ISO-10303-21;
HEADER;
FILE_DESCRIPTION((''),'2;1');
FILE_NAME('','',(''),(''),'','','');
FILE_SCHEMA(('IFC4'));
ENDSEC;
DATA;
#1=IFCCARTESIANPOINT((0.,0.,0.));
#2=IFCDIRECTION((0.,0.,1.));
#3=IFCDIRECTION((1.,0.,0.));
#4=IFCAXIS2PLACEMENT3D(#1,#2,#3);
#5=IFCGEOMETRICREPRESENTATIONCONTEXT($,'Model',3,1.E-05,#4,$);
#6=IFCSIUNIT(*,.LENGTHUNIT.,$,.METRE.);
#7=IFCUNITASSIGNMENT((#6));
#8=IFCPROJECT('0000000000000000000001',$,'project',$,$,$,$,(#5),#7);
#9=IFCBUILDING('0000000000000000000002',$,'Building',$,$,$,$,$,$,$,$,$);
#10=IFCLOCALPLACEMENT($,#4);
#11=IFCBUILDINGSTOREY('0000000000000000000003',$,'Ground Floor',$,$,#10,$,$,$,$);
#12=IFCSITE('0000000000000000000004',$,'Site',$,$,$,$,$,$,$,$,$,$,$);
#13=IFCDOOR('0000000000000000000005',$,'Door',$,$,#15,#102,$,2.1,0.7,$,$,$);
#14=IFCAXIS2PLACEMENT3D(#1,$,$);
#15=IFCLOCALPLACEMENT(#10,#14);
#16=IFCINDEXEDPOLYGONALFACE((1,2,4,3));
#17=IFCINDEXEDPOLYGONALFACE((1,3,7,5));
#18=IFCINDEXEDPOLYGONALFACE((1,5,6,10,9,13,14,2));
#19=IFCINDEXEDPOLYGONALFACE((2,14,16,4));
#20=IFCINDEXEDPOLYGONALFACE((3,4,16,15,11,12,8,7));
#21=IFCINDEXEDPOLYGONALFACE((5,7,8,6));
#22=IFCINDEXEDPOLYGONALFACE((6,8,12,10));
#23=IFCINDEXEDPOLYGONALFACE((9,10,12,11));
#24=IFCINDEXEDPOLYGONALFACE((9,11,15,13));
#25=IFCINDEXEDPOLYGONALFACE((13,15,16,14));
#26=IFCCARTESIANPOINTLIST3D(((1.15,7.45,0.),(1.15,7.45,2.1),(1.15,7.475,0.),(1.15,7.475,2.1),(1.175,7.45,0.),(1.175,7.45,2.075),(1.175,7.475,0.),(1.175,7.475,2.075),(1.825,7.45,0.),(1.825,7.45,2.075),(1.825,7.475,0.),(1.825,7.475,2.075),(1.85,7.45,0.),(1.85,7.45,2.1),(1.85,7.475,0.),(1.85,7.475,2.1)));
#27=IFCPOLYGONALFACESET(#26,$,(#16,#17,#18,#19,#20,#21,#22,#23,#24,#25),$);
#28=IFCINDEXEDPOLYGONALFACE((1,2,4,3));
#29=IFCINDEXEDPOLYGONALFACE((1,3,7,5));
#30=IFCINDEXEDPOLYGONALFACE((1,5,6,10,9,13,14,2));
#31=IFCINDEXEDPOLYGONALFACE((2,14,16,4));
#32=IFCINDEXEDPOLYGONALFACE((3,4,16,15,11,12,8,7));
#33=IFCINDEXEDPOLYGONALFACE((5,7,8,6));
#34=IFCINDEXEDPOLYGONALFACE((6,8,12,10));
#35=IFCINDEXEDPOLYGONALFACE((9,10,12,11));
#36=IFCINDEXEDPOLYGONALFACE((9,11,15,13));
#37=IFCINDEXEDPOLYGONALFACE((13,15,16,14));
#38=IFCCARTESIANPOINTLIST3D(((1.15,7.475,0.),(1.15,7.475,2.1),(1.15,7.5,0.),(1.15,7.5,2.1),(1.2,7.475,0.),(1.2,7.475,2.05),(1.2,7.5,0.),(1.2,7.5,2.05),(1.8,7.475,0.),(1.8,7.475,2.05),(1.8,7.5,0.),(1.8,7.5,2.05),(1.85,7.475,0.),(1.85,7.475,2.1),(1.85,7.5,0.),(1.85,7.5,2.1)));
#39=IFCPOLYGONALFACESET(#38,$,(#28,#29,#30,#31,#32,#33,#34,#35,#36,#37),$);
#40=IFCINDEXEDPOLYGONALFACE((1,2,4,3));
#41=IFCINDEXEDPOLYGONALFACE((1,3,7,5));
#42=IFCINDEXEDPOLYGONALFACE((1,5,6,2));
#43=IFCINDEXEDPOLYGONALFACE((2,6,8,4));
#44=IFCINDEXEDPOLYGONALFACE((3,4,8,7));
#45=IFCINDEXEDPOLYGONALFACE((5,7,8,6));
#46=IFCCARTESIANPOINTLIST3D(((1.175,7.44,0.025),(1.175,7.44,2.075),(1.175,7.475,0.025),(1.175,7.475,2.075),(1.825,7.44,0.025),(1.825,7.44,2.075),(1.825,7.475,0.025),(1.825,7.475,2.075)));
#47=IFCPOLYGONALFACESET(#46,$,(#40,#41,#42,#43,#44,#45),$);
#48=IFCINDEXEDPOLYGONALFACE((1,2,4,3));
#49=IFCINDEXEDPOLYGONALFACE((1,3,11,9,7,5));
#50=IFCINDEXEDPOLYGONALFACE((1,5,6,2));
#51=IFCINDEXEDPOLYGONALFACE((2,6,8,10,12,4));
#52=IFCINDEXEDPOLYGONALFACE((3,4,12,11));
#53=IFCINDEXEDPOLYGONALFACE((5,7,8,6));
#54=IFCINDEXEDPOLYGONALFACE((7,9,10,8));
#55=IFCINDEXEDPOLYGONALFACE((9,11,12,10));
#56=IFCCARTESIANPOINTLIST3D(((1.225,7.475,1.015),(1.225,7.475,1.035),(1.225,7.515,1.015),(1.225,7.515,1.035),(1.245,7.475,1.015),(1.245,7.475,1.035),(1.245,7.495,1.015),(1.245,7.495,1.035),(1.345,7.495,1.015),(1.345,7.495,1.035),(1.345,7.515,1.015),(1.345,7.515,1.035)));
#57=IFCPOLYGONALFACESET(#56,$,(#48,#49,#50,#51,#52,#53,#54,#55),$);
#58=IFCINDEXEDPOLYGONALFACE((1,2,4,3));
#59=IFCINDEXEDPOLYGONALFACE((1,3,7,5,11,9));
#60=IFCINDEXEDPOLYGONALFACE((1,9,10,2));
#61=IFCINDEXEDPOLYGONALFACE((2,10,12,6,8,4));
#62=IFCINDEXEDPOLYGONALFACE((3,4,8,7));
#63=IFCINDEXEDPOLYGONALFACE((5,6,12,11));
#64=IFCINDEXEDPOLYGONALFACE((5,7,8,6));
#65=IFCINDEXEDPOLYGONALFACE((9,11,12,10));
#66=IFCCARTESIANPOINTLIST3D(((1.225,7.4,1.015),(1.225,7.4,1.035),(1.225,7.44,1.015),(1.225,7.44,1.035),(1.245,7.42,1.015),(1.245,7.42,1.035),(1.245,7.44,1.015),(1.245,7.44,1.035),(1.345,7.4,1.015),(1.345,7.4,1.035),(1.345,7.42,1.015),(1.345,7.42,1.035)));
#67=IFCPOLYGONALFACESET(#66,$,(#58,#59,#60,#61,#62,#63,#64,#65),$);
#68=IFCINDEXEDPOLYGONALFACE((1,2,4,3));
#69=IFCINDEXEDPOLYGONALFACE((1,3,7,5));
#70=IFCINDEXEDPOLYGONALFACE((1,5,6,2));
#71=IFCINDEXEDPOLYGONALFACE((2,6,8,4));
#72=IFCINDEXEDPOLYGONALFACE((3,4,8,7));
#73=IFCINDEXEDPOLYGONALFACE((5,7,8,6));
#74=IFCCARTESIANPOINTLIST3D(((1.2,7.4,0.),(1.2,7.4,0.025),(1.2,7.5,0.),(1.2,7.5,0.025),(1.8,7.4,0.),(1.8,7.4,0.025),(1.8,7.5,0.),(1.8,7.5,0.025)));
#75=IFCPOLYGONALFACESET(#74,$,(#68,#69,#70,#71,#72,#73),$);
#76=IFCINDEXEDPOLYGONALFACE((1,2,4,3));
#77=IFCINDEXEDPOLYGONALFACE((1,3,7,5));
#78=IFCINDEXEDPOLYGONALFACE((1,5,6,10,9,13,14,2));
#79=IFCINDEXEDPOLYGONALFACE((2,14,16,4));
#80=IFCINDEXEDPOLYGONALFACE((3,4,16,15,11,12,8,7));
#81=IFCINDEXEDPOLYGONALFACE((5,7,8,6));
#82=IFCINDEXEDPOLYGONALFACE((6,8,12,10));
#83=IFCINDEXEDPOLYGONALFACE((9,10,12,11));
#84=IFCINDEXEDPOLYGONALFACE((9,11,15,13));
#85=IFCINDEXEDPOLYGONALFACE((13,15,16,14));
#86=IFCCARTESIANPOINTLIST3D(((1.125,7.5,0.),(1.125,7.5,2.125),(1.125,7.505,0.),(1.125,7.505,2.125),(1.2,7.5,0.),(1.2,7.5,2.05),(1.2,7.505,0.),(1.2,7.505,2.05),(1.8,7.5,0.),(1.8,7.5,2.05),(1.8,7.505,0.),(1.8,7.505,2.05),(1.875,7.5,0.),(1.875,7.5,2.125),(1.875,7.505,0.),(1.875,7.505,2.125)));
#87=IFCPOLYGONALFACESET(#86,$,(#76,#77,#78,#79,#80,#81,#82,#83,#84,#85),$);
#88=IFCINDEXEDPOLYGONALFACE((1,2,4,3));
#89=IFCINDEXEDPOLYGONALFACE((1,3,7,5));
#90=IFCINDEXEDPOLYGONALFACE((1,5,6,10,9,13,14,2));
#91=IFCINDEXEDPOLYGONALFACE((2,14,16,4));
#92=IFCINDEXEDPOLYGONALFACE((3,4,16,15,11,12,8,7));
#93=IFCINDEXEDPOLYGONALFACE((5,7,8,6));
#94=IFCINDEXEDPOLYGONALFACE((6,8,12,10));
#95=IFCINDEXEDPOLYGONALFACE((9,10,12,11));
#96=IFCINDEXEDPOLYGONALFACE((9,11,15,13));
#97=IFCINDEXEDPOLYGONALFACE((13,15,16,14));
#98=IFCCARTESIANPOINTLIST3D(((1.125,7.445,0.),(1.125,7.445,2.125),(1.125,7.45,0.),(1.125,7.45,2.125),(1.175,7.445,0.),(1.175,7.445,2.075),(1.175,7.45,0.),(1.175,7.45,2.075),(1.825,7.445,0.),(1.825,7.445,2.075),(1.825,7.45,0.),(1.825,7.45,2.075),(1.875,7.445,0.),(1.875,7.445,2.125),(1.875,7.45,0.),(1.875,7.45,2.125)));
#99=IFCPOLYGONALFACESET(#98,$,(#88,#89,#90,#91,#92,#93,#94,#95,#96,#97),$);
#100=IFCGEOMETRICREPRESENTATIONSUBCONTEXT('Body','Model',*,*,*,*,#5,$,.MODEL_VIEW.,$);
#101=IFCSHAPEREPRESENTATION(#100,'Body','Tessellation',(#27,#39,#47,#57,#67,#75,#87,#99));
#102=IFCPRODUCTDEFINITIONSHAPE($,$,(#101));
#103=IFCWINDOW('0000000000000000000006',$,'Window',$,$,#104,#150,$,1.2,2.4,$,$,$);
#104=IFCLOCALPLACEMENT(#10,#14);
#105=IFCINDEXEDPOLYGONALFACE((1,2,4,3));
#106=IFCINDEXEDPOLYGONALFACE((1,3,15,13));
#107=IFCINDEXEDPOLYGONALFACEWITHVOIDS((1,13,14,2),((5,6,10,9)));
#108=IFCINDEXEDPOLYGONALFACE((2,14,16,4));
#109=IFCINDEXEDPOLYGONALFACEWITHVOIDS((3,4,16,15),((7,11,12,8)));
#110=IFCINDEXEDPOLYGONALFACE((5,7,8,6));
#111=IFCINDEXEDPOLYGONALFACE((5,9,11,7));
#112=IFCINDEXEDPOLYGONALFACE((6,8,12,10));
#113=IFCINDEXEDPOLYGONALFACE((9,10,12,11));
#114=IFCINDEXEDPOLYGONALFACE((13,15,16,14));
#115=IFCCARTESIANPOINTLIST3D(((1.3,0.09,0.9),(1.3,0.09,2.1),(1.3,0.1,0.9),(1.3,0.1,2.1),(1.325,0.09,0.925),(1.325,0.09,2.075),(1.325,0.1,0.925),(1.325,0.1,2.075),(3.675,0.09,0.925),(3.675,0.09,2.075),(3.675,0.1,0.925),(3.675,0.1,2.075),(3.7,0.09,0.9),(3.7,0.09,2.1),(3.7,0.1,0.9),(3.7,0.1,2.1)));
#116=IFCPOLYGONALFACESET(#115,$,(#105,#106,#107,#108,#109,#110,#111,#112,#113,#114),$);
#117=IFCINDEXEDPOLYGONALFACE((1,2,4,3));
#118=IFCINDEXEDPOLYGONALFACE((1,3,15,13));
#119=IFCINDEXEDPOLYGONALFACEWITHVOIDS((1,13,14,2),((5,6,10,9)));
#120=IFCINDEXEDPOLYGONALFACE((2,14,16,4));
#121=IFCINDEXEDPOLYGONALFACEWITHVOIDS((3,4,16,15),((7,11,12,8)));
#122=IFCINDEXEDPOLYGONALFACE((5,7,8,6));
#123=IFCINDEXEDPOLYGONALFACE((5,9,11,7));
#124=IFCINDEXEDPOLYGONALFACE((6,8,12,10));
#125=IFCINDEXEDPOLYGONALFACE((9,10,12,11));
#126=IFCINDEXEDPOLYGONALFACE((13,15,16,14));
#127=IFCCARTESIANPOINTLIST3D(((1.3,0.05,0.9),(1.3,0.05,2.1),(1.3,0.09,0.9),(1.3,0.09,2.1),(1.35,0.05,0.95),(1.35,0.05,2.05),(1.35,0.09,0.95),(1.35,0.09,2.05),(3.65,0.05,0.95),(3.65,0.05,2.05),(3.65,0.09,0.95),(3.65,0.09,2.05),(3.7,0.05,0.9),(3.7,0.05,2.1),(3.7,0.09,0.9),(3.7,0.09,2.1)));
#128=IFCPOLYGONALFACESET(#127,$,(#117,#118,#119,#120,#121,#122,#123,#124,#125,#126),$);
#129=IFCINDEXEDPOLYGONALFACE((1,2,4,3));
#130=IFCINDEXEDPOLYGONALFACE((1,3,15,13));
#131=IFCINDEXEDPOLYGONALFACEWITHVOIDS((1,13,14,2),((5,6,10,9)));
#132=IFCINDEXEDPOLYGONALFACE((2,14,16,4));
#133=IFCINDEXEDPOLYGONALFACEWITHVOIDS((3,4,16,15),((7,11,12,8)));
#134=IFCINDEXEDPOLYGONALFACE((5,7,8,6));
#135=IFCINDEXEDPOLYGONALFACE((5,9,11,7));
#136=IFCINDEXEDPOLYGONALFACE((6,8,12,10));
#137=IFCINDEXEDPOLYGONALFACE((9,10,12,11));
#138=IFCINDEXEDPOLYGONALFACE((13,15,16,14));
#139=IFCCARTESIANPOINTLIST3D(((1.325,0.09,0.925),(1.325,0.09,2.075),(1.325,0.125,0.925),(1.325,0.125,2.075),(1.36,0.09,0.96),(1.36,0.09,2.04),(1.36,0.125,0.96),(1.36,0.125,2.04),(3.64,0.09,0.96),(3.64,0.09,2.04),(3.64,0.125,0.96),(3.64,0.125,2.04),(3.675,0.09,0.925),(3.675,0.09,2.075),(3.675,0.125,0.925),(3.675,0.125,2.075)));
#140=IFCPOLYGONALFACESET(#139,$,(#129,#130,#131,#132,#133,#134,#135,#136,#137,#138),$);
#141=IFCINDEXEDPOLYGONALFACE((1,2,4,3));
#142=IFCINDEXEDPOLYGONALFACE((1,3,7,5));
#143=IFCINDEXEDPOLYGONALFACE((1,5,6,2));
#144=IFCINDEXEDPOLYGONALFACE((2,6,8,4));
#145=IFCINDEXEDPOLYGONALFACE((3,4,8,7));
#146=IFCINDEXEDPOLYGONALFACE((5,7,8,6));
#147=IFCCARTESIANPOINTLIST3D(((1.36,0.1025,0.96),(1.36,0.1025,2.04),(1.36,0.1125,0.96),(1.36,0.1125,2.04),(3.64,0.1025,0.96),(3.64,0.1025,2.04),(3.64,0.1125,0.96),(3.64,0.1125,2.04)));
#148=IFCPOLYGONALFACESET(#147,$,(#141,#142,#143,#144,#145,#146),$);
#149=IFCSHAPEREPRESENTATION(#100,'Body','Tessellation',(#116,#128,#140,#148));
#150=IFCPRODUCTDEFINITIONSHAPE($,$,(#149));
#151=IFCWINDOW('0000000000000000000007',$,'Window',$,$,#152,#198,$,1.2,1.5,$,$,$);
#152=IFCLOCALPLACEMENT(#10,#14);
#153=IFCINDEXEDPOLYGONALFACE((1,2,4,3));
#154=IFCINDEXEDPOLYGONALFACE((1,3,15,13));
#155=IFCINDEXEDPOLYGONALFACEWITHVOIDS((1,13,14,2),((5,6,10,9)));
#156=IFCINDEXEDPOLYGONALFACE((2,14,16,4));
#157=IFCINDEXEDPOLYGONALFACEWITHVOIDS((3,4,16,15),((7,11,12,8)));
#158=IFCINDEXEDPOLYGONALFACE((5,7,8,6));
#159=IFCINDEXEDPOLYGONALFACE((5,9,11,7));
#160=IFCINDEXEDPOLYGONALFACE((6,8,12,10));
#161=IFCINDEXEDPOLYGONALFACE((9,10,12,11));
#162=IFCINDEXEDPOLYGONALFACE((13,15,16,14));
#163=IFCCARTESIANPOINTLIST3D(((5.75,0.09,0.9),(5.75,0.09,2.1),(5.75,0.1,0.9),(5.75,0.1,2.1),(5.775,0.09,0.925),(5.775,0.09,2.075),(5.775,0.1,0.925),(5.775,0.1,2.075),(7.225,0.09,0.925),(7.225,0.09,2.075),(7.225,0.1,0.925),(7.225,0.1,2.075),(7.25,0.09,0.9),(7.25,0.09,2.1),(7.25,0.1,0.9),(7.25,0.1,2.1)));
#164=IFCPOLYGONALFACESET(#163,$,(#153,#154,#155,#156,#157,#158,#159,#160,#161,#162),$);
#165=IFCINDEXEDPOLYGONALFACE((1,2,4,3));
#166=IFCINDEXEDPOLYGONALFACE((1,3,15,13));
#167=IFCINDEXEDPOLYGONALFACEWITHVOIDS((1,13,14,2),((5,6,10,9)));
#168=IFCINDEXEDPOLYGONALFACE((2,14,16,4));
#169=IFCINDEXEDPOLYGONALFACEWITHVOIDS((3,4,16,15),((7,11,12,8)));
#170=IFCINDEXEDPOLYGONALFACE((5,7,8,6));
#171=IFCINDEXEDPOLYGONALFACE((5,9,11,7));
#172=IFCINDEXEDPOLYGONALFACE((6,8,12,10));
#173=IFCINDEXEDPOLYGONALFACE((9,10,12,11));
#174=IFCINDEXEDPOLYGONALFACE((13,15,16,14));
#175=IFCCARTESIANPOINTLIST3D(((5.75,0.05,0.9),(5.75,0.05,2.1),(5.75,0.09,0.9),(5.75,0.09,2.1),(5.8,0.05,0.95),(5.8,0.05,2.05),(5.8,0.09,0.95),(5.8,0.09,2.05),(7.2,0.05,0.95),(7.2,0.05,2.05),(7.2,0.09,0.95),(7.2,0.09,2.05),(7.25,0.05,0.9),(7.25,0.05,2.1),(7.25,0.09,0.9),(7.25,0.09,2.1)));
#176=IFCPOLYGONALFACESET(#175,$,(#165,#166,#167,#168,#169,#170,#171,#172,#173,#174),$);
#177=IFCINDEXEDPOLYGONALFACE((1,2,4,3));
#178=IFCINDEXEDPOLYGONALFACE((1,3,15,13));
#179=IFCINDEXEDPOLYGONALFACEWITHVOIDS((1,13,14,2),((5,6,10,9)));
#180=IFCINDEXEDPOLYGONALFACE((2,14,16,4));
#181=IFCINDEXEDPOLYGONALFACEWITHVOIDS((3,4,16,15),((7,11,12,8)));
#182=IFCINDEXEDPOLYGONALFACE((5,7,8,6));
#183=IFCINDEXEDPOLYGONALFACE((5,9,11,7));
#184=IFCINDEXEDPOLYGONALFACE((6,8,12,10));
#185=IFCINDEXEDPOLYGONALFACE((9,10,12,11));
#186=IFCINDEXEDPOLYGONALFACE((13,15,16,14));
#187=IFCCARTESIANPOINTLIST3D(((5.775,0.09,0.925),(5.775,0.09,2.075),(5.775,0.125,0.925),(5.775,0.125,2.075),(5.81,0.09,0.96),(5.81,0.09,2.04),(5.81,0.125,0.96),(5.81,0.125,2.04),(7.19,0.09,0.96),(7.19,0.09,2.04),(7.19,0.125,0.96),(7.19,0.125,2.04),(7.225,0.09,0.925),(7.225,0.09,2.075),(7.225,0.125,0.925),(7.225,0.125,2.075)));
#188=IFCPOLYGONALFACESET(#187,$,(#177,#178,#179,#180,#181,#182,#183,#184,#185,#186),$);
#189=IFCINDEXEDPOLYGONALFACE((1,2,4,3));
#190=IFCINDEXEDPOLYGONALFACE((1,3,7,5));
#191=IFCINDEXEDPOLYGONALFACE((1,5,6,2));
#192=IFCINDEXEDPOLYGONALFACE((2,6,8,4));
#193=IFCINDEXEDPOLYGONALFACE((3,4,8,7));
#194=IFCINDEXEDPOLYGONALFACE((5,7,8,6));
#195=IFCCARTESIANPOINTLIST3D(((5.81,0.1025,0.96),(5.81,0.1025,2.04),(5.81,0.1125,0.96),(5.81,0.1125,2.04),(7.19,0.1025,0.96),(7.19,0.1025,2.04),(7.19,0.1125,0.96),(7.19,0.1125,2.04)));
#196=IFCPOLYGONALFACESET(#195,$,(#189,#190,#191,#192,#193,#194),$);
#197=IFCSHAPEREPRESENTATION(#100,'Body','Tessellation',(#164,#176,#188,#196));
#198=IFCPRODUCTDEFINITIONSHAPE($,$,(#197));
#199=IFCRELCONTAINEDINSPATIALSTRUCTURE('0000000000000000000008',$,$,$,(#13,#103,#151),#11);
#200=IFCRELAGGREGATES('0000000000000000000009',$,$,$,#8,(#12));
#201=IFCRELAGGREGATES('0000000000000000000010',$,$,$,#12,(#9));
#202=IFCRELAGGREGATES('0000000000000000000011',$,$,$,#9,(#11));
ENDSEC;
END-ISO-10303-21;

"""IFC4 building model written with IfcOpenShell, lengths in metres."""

from ifc_helpers import new_model, si_unit, frame, origin_with_axes, place, context, subcontext, project, spatial, line, indexed_curve, outline, extrude, element, save


model = new_model("IFC4")

# Units and contexts
model_context = context("Model", 3, precision=1e-05, world=origin_with_axes())
body_context = subcontext(model_context, "Body", "Model", "MODEL_VIEW")
ifc_project = project(units=[si_unit("LENGTHUNIT", "METRE")], contexts=[model_context])

# Site, building, storey
site = spatial("IfcSite", under=ifc_project, Name="Site")
building = spatial("IfcBuilding", under=site, Name="Building")
storey_placement = place(None, origin_with_axes())
storey = spatial("IfcBuildingStorey", under=building, at=storey_placement, Name="Ground Floor")

# Door
door_1_placement = place(storey_placement, frame((1.85, 7.5, 0.0), z_axis=(0.0, 0.0, 1.0), x_axis=(-1.0, 0.0, 0.0)))
element("IfcDoor", 1, at=door_1_placement, inside=storey, Name="Door", OverallHeight=2.1, OverallWidth=0.7, context=body_context, shape_type="SweptSolid", body=[
    extrude(outline(indexed_curve([(0.0, 0.0), (0.0, 2.1), (0.7, 2.1), (0.7, 0.0), (0.675, 0.0), (0.675, 2.075), (0.025, 2.075), (0.025, 0.0)], segments=[line(1, 2, 3, 4, 5, 6, 7, 8, 1)])), frame((0.0, 0.025, 0.0), z_axis=(0.0, -1.0, 0.0), x_axis=(1.0, 0.0, 0.0)), (0.0, 0.0, -1.0), 0.025),
    extrude(outline(indexed_curve([(0.0, 0.0), (0.0, 2.1), (0.7, 2.1), (0.7, 0.0), (0.65, 0.0), (0.65, 2.05), (0.05, 2.05), (0.05, 0.0)], segments=[line(1, 2, 3, 4, 5, 6, 7, 8, 1)])), frame((0.0, 0.0, 0.0), z_axis=(0.0, -1.0, 0.0), x_axis=(1.0, 0.0, 0.0)), (0.0, 0.0, -1.0), 0.025),
    extrude(outline(indexed_curve([(0.0, 0.0), (0.65, 0.0), (0.65, 0.035), (0.0, 0.035)], segments=[line(1, 2, 3, 4, 1)])), frame((0.025, 0.025, 0.025), z_axis=(0.0, 0.0, 1.0), x_axis=(1.0, 0.0, 0.0)), (0.0, 0.0, 1.0), 2.05),
    extrude(outline(indexed_curve([(0.0, 0.0), (0.0, -0.04), (-0.12, -0.04), (-0.12, -0.02), (-0.02, -0.02), (-0.02, 0.0)], segments=[line(1, 2, 3, 4, 5, 6, 1)])), frame((0.625, 0.025, 1.015), z_axis=(0.0, 0.0, 1.0), x_axis=(1.0, 0.0, 0.0)), (0.0, 0.0, 1.0), 0.02),
    extrude(outline(indexed_curve([(0.0, 0.0), (0.0, 0.04), (-0.12, 0.04), (-0.12, 0.02), (-0.02, 0.02), (-0.02, 0.0)], segments=[line(1, 2, 3, 4, 5, 6, 1)])), frame((0.625, 0.06, 1.015), z_axis=(0.0, 0.0, 1.0), x_axis=(1.0, 0.0, 0.0)), (0.0, 0.0, 1.0), 0.02),
    extrude(outline(indexed_curve([(0.0, 0.0), (0.6, 0.0), (0.6, 0.1), (0.0, 0.1)], segments=[line(1, 2, 3, 4, 1)])), frame((0.05, 0.0, 0.0), z_axis=(0.0, 0.0, 1.0), x_axis=(1.0, 0.0, 0.0)), (0.0, 0.0, 1.0), 0.025),
    extrude(outline(indexed_curve([(0.0, 0.0), (0.0, 2.125), (0.75, 2.125), (0.75, 0.0), (0.675, 0.0), (0.675, 2.05), (0.075, 2.05), (0.075, 0.0)], segments=[line(1, 2, 3, 4, 5, 6, 7, 8, 1)])), frame((-0.025, -0.005, 0.0), z_axis=(0.0, -1.0, 0.0), x_axis=(1.0, 0.0, 0.0)), (0.0, 0.0, -1.0), 0.005),
    extrude(outline(indexed_curve([(0.0, 0.0), (0.0, 2.125), (0.75, 2.125), (0.75, 0.0), (0.7, 0.0), (0.7, 2.075), (0.05, 2.075), (0.05, 0.0)], segments=[line(1, 2, 3, 4, 5, 6, 7, 8, 1)])), frame((-0.025, 0.05, 0.0), z_axis=(0.0, -1.0, 0.0), x_axis=(1.0, 0.0, 0.0)), (0.0, 0.0, -1.0), 0.005),
])

# Windows
window_1_placement = place(storey_placement, frame((1.3, 0.0, 0.9), z_axis=(0.0, 0.0, 1.0), x_axis=(1.0, 0.0, 0.0)))
element("IfcWindow", 2, at=window_1_placement, inside=storey, Name="Window", OverallHeight=1.2, OverallWidth=2.4, context=body_context, shape_type="SweptSolid", body=[
    extrude(outline(indexed_curve([(0.0, 0.0), (2.4, 0.0), (2.4, 1.2), (0.0, 1.2)], segments=[line(1, 2, 3, 4, 1)]), holes=[indexed_curve([(0.025, 0.025), (2.375, 0.025), (2.375, 1.175), (0.025, 1.175)], segments=[line(1, 2, 3, 4, 1)])]), frame((0.0, 0.09, 0.0), z_axis=(0.0, -1.0, 0.0), x_axis=(1.0, 0.0, 0.0)), (0.0, 0.0, -1.0), 0.01),
    extrude(outline(indexed_curve([(0.0, 0.0), (2.4, 0.0), (2.4, 1.2), (0.0, 1.2)], segments=[line(1, 2, 3, 4, 1)]), holes=[indexed_curve([(0.05, 0.05), (2.35, 0.05), (2.35, 1.15), (0.05, 1.15)], segments=[line(1, 2, 3, 4, 1)])]), frame((0.0, 0.05, 0.0), z_axis=(0.0, -1.0, 0.0), x_axis=(1.0, 0.0, 0.0)), (0.0, 0.0, -1.0), 0.04),
    extrude(outline(indexed_curve([(0.0, 0.0), (2.35, 0.0), (2.35, 1.15), (0.0, 1.15)], segments=[line(1, 2, 3, 4, 1)]), holes=[indexed_curve([(0.035, 0.035), (2.315, 0.035), (2.315, 1.115), (0.035, 1.115)], segments=[line(1, 2, 3, 4, 1)])]), frame((0.025, 0.09, 0.025), z_axis=(0.0, -1.0, 0.0), x_axis=(1.0, 0.0, 0.0)), (0.0, 0.0, -1.0), 0.035),
    extrude(outline(indexed_curve([(0.035, 0.035), (2.315, 0.035), (2.315, 1.115), (0.035, 1.115)], segments=[line(1, 2, 3, 4, 1)])), frame((0.025, 0.1025, 0.025), z_axis=(0.0, -1.0, 0.0), x_axis=(1.0, 0.0, 0.0)), (0.0, 0.0, -1.0), 0.01),
])
for number, where, z_axis, x_axis, name in (
    (3, (5.75, 0.0, 0.9), (0.0, 0.0, 1.0), (1.0, 0.0, 0.0), "Window"),
):
    element("IfcWindow", number, at=place(storey_placement, frame(where, z_axis=z_axis, x_axis=x_axis)), inside=storey, Name=name, OverallHeight=1.2, OverallWidth=1.5, context=body_context, shape_type="SweptSolid", body=[
        extrude(outline(indexed_curve([(0.0, 0.0), (1.5, 0.0), (1.5, 1.2), (0.0, 1.2)], segments=[line(1, 2, 3, 4, 1)]), holes=[indexed_curve([(0.025, 0.025), (1.475, 0.025), (1.475, 1.175), (0.025, 1.175)], segments=[line(1, 2, 3, 4, 1)])]), frame((0.0, 0.09, 0.0), z_axis=(0.0, -1.0, 0.0), x_axis=(1.0, 0.0, 0.0)), (0.0, 0.0, -1.0), 0.01),
        extrude(outline(indexed_curve([(0.0, 0.0), (1.5, 0.0), (1.5, 1.2), (0.0, 1.2)], segments=[line(1, 2, 3, 4, 1)]), holes=[indexed_curve([(0.05, 0.05), (1.45, 0.05), (1.45, 1.15), (0.05, 1.15)], segments=[line(1, 2, 3, 4, 1)])]), frame((0.0, 0.05, 0.0), z_axis=(0.0, -1.0, 0.0), x_axis=(1.0, 0.0, 0.0)), (0.0, 0.0, -1.0), 0.04),
        extrude(outline(indexed_curve([(0.0, 0.0), (1.45, 0.0), (1.45, 1.15), (0.0, 1.15)], segments=[line(1, 2, 3, 4, 1)]), holes=[indexed_curve([(0.035, 0.035), (1.415, 0.035), (1.415, 1.115), (0.035, 1.115)], segments=[line(1, 2, 3, 4, 1)])]), frame((0.025, 0.09, 0.025), z_axis=(0.0, -1.0, 0.0), x_axis=(1.0, 0.0, 0.0)), (0.0, 0.0, -1.0), 0.035),
        extrude(outline(indexed_curve([(0.035, 0.035), (1.415, 0.035), (1.415, 1.115), (0.035, 1.115)], segments=[line(1, 2, 3, 4, 1)])), frame((0.025, 0.1025, 0.025), z_axis=(0.0, -1.0, 0.0), x_axis=(1.0, 0.0, 0.0)), (0.0, 0.0, -1.0), 0.01),
    ])

save(model, "model.ifc")
